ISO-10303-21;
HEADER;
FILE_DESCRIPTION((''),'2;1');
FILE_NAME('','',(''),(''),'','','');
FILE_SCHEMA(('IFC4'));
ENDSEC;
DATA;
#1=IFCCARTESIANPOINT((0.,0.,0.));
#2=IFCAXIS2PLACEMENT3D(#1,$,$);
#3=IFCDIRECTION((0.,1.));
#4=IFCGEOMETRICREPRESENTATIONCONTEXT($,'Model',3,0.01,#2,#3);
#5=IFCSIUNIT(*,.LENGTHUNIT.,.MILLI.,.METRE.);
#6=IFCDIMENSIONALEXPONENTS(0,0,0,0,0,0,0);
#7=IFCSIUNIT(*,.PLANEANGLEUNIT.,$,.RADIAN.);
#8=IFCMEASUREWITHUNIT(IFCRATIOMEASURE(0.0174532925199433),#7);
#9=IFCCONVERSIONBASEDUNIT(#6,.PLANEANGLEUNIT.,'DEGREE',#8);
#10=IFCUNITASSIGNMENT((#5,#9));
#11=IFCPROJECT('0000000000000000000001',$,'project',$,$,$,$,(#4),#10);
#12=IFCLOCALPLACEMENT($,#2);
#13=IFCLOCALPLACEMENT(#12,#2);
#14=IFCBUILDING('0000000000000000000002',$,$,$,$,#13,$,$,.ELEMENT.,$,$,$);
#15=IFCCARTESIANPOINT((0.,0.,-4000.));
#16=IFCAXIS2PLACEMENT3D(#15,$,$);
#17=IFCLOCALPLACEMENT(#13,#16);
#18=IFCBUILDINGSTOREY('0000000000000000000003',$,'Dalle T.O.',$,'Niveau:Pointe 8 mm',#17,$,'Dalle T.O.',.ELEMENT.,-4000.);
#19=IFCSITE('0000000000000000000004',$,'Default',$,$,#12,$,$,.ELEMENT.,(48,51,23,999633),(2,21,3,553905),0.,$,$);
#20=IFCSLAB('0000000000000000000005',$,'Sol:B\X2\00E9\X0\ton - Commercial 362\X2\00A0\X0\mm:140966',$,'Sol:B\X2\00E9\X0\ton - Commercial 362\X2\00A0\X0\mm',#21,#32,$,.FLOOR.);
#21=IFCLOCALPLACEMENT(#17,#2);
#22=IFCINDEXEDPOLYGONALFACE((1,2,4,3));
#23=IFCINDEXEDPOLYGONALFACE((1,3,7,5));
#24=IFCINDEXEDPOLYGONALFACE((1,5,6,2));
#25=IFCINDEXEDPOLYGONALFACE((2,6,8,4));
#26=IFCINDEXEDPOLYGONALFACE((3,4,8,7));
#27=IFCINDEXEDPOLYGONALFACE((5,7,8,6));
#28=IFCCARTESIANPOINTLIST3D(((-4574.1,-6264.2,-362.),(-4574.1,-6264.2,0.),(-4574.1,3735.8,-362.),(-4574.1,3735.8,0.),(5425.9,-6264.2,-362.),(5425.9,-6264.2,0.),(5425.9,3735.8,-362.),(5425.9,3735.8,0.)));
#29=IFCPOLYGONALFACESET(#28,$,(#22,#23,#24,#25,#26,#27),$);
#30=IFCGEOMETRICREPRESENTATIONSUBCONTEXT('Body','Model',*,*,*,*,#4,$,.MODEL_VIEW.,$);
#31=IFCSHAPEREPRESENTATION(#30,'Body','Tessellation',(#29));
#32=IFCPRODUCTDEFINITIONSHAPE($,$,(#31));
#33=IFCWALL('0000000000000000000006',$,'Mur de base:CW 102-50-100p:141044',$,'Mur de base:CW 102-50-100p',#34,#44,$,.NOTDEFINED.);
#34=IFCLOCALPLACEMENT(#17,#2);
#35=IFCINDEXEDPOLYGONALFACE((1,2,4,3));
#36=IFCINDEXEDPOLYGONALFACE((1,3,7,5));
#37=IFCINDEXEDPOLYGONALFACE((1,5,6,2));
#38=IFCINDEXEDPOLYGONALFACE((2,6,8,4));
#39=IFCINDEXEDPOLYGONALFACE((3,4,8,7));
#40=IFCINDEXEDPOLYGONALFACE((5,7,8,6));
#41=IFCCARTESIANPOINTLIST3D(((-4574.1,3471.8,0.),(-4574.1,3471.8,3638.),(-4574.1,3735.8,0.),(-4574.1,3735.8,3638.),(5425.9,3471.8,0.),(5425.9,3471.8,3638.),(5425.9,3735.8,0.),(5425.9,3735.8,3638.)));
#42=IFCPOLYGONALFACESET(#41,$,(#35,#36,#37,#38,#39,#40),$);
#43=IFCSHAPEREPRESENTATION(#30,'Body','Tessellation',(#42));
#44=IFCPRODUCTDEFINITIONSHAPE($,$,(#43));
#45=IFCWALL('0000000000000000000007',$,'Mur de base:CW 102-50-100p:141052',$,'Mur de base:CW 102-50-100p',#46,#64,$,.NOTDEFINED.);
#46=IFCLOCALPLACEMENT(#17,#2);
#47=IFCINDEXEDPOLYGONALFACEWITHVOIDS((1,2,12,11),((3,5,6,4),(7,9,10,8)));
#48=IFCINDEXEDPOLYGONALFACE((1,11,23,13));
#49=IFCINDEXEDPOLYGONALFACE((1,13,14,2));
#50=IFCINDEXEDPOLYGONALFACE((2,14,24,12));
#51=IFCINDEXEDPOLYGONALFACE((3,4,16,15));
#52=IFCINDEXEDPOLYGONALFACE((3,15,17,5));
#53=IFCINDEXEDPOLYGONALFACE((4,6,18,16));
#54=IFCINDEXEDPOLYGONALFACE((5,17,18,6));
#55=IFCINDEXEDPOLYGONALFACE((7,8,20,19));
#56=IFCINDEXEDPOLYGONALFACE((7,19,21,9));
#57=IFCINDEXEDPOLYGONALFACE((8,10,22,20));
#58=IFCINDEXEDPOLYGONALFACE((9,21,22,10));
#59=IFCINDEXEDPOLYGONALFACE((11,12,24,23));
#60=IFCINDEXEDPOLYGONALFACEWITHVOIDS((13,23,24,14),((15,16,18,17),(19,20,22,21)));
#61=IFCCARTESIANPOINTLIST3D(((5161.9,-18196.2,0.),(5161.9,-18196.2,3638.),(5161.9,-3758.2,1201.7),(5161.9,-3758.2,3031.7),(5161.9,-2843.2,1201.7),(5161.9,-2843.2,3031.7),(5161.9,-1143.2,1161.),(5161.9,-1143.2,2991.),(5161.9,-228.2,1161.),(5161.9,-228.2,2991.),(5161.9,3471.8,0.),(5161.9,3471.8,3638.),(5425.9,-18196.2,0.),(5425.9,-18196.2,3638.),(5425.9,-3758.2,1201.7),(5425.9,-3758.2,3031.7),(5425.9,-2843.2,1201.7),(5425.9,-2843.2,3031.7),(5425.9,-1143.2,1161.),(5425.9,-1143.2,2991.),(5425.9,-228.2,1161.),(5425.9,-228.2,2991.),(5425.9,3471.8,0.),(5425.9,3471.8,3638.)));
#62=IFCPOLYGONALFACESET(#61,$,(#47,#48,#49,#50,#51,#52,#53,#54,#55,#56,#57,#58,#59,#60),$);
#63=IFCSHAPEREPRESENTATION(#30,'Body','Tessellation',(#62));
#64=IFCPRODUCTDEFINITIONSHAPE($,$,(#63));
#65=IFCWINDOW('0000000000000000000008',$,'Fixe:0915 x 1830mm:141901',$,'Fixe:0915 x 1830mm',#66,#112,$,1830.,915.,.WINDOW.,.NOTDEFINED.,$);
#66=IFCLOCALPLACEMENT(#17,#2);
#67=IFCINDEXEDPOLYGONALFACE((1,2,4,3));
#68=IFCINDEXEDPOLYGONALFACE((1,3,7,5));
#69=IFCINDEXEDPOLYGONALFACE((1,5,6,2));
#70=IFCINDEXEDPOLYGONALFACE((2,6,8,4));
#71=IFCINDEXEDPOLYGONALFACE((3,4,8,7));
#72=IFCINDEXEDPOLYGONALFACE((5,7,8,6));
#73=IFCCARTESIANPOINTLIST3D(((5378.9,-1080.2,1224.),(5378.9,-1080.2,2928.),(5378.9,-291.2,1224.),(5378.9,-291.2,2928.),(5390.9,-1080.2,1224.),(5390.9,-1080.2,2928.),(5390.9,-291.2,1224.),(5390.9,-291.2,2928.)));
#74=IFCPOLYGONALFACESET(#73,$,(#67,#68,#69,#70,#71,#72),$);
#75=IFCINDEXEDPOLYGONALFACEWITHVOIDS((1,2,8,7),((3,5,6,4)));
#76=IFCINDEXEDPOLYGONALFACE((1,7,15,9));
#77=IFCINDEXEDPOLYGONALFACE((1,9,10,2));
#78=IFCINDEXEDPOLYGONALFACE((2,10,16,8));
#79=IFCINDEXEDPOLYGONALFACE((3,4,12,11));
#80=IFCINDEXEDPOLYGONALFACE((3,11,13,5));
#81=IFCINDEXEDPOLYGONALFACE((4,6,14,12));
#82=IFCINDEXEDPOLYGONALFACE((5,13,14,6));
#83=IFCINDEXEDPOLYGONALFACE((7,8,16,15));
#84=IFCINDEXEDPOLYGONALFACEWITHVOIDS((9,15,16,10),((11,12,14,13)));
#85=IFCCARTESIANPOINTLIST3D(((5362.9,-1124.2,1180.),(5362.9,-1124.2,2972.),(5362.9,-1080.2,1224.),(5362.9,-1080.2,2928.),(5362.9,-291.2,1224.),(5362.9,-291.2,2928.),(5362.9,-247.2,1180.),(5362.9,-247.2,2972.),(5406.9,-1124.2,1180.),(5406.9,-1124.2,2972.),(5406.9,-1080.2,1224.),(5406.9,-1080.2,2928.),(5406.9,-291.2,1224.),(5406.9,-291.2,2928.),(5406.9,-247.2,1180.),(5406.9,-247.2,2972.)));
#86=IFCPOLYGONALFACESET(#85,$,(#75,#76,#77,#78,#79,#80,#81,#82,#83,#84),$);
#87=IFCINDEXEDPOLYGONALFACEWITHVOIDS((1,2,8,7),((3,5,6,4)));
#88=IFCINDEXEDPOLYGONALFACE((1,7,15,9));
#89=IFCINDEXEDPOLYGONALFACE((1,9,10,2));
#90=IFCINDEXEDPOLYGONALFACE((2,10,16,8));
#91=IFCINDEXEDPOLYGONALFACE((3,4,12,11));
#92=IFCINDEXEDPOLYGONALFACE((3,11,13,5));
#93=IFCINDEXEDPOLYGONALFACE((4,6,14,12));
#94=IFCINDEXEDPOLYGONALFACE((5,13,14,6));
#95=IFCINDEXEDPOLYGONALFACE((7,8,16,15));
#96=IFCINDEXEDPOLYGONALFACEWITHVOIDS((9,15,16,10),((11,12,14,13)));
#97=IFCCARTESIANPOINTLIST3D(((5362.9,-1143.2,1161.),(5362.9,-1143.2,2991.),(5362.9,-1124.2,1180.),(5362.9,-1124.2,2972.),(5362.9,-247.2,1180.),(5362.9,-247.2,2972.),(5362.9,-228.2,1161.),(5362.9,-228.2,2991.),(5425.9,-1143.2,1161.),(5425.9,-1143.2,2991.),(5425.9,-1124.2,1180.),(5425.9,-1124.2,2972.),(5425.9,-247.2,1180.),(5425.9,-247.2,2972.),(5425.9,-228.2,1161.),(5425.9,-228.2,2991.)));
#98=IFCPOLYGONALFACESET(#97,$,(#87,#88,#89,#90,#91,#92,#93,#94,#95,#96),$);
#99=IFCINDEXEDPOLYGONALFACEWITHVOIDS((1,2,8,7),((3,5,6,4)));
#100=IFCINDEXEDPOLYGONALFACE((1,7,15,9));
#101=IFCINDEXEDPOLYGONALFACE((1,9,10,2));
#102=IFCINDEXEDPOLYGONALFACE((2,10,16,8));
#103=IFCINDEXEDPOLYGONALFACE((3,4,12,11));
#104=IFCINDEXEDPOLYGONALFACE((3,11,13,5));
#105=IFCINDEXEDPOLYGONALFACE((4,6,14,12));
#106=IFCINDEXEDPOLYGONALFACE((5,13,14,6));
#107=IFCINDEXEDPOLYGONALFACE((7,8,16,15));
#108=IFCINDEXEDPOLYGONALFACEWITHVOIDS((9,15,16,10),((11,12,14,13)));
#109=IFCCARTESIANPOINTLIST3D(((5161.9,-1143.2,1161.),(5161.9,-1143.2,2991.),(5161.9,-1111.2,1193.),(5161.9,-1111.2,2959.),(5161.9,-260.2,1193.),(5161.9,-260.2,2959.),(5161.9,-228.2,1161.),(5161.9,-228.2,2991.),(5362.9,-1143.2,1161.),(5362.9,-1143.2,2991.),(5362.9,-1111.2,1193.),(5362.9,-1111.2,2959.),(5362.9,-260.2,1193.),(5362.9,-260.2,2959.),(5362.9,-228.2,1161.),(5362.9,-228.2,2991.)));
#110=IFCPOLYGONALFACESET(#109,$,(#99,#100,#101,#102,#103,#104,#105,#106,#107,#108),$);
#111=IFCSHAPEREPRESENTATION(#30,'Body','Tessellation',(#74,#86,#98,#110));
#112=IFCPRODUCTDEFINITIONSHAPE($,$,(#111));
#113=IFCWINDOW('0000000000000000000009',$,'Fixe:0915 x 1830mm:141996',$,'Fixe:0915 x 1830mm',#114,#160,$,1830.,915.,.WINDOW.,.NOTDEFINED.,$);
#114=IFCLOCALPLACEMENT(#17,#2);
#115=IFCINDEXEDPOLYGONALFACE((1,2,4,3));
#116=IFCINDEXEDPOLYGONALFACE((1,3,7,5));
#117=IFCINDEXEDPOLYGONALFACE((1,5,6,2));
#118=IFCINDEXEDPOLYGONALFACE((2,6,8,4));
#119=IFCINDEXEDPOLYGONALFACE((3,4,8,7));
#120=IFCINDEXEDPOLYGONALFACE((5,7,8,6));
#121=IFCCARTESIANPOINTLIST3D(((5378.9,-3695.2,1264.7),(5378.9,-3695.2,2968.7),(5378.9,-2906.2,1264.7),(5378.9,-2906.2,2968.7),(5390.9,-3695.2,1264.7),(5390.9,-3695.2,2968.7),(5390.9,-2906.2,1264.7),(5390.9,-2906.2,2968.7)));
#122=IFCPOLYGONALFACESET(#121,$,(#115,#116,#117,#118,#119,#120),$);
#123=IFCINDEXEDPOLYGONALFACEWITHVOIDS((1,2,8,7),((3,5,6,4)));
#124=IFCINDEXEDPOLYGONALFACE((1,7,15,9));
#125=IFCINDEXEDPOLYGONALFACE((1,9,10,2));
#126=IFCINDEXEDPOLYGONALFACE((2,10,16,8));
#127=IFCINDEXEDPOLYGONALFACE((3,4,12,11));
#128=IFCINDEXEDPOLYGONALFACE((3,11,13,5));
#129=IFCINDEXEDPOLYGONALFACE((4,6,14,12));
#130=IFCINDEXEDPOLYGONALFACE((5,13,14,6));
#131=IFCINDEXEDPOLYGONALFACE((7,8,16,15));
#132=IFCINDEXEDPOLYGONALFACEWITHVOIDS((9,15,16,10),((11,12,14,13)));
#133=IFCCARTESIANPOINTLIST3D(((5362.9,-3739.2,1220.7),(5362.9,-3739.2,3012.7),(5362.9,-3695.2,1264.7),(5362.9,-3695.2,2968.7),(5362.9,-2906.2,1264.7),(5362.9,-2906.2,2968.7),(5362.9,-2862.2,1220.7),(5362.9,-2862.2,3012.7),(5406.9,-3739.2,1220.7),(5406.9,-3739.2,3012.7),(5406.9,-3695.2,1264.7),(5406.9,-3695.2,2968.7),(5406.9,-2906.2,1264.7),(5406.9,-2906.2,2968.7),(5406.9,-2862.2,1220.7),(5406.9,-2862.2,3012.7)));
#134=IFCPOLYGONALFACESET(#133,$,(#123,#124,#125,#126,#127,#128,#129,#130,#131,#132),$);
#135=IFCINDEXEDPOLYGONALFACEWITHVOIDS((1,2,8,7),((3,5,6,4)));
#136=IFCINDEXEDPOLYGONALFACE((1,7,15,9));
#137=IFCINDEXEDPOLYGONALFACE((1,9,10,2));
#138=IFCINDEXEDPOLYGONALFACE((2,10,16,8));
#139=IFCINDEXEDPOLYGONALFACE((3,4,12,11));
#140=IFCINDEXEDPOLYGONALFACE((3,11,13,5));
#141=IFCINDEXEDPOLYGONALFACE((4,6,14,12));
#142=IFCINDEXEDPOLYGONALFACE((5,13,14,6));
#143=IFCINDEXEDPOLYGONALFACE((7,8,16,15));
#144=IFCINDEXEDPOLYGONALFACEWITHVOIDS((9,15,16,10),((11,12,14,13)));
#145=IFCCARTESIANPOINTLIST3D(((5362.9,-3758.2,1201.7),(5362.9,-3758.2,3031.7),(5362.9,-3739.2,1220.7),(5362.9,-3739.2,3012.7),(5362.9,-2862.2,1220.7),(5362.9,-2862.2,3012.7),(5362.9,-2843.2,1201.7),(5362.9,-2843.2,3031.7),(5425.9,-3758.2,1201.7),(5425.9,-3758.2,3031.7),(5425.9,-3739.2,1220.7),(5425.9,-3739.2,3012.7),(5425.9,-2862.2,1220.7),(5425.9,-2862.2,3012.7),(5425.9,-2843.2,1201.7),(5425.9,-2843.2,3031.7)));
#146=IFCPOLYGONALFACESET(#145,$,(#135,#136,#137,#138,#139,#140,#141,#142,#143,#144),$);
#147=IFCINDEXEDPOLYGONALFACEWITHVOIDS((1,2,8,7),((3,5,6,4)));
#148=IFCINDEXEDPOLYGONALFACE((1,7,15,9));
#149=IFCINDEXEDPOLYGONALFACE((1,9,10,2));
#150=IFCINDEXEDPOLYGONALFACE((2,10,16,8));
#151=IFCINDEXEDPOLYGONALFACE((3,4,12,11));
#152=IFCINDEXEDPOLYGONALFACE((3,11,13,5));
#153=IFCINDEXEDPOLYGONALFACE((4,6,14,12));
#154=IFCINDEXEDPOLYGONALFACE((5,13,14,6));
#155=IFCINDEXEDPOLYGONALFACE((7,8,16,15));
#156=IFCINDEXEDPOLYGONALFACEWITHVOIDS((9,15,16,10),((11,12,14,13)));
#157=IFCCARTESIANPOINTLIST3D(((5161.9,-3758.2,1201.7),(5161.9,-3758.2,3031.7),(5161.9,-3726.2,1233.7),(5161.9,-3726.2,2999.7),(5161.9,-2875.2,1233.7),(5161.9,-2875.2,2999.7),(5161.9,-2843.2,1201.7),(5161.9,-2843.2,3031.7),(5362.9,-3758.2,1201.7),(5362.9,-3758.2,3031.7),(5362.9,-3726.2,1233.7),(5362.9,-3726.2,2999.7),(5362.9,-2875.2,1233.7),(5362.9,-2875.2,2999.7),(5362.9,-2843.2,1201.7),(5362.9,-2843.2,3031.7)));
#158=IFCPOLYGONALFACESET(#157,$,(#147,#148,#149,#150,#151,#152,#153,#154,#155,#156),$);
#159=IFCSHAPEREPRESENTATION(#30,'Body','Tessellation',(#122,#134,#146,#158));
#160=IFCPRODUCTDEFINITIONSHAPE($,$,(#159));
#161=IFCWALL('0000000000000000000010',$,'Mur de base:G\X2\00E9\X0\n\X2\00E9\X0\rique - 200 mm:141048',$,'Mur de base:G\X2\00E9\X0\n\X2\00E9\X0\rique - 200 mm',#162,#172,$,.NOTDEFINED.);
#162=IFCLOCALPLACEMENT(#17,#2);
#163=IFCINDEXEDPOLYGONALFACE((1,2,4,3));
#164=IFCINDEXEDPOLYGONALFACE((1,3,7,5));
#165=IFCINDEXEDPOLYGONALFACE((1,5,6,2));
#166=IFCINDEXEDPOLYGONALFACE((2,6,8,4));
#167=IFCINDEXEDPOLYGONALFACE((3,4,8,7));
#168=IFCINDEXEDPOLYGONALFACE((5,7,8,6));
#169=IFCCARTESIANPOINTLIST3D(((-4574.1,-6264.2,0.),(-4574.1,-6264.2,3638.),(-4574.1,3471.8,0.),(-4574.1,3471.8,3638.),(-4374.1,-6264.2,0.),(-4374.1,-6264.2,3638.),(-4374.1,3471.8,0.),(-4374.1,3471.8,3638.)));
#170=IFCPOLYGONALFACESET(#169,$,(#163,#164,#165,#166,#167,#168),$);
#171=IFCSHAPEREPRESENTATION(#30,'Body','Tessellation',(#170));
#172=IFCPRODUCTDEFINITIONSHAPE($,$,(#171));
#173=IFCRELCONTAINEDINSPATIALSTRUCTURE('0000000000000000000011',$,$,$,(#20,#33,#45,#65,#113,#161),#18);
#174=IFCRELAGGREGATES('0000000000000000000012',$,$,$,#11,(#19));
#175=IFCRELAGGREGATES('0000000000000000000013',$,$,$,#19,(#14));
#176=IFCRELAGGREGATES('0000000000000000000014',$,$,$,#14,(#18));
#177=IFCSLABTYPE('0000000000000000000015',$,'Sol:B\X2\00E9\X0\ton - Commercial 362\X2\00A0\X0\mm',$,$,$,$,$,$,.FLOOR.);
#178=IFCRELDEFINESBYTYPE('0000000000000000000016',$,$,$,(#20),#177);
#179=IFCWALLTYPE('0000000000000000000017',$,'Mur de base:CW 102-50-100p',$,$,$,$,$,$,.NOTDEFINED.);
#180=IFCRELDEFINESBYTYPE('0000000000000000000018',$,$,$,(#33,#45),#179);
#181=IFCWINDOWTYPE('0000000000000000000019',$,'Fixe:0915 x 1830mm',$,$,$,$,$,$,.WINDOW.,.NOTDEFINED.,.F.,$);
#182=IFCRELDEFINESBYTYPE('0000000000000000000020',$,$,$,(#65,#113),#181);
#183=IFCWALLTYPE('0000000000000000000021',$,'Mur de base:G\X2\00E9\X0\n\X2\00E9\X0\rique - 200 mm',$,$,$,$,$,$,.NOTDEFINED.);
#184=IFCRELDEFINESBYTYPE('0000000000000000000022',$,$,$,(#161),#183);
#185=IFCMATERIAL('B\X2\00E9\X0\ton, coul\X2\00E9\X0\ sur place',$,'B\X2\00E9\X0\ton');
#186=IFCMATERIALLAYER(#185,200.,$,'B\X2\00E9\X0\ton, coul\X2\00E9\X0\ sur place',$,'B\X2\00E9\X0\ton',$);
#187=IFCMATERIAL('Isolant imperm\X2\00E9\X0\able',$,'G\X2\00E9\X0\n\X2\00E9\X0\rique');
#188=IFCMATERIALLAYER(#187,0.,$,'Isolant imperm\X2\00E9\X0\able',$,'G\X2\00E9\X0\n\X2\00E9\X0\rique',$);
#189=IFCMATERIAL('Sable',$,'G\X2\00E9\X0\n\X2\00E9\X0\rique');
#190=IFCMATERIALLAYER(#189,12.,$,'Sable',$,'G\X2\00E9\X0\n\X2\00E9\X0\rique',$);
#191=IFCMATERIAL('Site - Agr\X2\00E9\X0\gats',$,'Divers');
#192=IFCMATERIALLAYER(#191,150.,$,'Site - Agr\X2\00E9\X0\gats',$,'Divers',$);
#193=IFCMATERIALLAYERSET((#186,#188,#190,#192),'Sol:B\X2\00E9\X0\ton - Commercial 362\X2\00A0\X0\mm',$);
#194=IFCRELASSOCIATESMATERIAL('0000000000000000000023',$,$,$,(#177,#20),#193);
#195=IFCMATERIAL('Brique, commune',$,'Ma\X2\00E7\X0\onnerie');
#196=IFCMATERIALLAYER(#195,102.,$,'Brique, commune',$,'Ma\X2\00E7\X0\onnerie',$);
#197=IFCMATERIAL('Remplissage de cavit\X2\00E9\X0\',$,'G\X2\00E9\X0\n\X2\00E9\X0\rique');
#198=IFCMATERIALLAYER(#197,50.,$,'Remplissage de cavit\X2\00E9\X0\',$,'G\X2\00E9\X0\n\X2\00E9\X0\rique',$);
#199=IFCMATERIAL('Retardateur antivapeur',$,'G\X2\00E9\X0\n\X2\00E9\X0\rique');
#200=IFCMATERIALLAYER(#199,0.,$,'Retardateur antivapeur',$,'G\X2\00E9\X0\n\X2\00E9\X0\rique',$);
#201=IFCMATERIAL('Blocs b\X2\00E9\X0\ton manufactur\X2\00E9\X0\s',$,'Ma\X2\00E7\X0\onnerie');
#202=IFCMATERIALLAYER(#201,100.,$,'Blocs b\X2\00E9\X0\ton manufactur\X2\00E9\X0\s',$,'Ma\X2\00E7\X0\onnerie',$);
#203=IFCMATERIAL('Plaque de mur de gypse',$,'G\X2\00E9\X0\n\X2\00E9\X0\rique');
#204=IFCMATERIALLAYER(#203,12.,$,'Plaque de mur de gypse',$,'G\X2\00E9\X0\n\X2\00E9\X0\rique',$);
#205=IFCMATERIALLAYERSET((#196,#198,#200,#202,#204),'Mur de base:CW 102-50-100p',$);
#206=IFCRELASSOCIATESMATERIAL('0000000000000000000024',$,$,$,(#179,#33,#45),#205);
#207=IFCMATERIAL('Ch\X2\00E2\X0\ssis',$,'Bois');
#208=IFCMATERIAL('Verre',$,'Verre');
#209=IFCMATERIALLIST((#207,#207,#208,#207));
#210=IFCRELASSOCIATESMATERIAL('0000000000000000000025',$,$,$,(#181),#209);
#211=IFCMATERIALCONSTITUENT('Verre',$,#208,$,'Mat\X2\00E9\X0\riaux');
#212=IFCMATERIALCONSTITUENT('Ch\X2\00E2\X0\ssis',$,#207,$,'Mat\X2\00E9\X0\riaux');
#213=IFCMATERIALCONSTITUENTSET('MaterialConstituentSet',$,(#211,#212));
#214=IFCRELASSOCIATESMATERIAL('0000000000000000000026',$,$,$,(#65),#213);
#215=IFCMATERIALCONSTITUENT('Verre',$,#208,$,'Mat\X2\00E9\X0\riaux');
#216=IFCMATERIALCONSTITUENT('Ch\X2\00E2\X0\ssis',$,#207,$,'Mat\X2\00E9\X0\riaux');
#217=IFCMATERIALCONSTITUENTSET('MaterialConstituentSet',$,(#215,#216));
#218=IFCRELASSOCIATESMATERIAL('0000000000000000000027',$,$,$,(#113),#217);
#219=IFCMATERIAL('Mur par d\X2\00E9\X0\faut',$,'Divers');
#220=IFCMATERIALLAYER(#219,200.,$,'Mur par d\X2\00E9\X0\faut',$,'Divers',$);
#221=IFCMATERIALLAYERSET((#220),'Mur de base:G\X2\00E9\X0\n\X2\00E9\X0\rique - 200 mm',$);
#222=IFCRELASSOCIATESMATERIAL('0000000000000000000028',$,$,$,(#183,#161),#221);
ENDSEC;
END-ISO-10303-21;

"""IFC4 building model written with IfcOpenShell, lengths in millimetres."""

from ifc_helpers import new_model, entity, si_unit, converted_unit, direction, frame, frame_2d, origin, place, context, subcontext, project, spatial, polyline, rectangle, outline, extrude, source, transform, mapped, material, material_list, layer, layer_set, layer_usage, constituent, constituent_set, type_object, type_shapes, element, fill, save


model = new_model("IFC4")

# Units and contexts
model_context = context("Model", 3, precision=0.01, world=origin(), true_north=direction((0.0, 1.0)))
body_context = subcontext(model_context, "Body", "Model", "MODEL_VIEW")
ifc_project = project(units=[si_unit("LENGTHUNIT", "METRE", prefix="MILLI"), converted_unit("PLANEANGLEUNIT", "DEGREE", entity("IfcRatioMeasure", 0.0174532925199433), si_unit("PLANEANGLEUNIT", "RADIAN"), dimensions=[0, 0, 0, 0, 0, 0, 0])], contexts=[model_context])

# Site, building, storey
site_placement = place(None, origin())
site = spatial("IfcSite", under=ifc_project, at=site_placement, Name="Default", CompositionType="ELEMENT", RefLatitude=(48, 51, 23, 999633), RefLongitude=(2, 21, 3, 553905), RefElevation=0.0)
building_placement = place(site_placement, origin())
building = spatial("IfcBuilding", under=site, at=building_placement, CompositionType="ELEMENT")
storey_placement = place(building_placement, frame((0.0, 0.0, -4000.0)))
storey = spatial("IfcBuildingStorey", under=building, at=storey_placement, Name="Dalle T.O.", ObjectType="Niveau:Pointe 8 mm", LongName="Dalle T.O.", CompositionType="ELEMENT", Elevation=-4000.0)

# Slab
ifc_material_1 = material(Name="Béton, coulé sur place", Category="Béton")
ifc_layer_1 = layer(ifc_material_1, 200.0, Name="Béton, coulé sur place", Category="Béton")
ifc_material_2 = material(Name="Isolant imperméable", Category="Générique")
ifc_layer_2 = layer(ifc_material_2, 0.0, Name="Isolant imperméable", Category="Générique")
ifc_material_3 = material(Name="Sable", Category="Générique")
ifc_layer_3 = layer(ifc_material_3, 12.0, Name="Sable", Category="Générique")
ifc_material_4 = material(Name="Site - Agrégats", Category="Divers")
ifc_layer_4 = layer(ifc_material_4, 150.0, Name="Site - Agrégats", Category="Divers")
ifc_layer_set_1 = layer_set([ifc_layer_1, ifc_layer_2, ifc_layer_3, ifc_layer_4], Name="Sol:Béton - Commercial 362 mm")
ifc_layer_usage_1 = layer_usage(ifc_layer_set_1, "AXIS3", "POSITIVE", 0.0)
slab_type = type_object("IfcSlabType", Name="Sol:Béton - Commercial 362 mm", PredefinedType="FLOOR", material=ifc_layer_set_1)
slab_placement = place(storey_placement, origin())
element("IfcSlab", 1, at=slab_placement, inside=storey, type_object=slab_type, material=ifc_layer_usage_1, Name="Sol:Béton - Commercial 362 mm:140966", ObjectType="Sol:Béton - Commercial 362 mm", PredefinedType="FLOOR", context=body_context, shape_type="SweptSolid", body=[
    extrude(rectangle(XDim=10000.0, YDim=10000.0, at=frame_2d((0.0, 0.0), x_axis=(1.0, 0.0))), frame((425.9, -1264.2, 0.0), z_axis=(0.0, 0.0, -1.0), x_axis=(0.0, 1.0, 0.0)), (0.0, 0.0, 1.0), 362.0),
])

# Wall
ifc_material_5 = material(Name="Brique, commune", Category="Maçonnerie")
ifc_layer_5 = layer(ifc_material_5, 102.0, Name="Brique, commune", Category="Maçonnerie")
ifc_material_6 = material(Name="Remplissage de cavité", Category="Générique")
ifc_layer_6 = layer(ifc_material_6, 50.0, Name="Remplissage de cavité", Category="Générique")
ifc_material_7 = material(Name="Retardateur antivapeur", Category="Générique")
ifc_layer_7 = layer(ifc_material_7, 0.0, Name="Retardateur antivapeur", Category="Générique")
ifc_material_8 = material(Name="Blocs béton manufacturés", Category="Maçonnerie")
ifc_layer_8 = layer(ifc_material_8, 100.0, Name="Blocs béton manufacturés", Category="Maçonnerie")
ifc_material_9 = material(Name="Plaque de mur de gypse", Category="Générique")
ifc_layer_9 = layer(ifc_material_9, 12.0, Name="Plaque de mur de gypse", Category="Générique")
ifc_layer_set_2 = layer_set([ifc_layer_5, ifc_layer_6, ifc_layer_7, ifc_layer_8, ifc_layer_9], Name="Mur de base:CW 102-50-100p")
ifc_layer_usage_2 = layer_usage(ifc_layer_set_2, "AXIS2", "NEGATIVE", 132.0)
wall_type_1 = type_object("IfcWallType", Name="Mur de base:CW 102-50-100p", PredefinedType="NOTDEFINED", material=ifc_layer_set_2)
wall_1_placement = place(storey_placement, frame((-4574.1, 3603.8, 0.0)))
element("IfcWall", 2, at=wall_1_placement, inside=storey, type_object=wall_type_1, material=ifc_layer_usage_2, Name="Mur de base:CW 102-50-100p:141044", ObjectType="Mur de base:CW 102-50-100p", PredefinedType="NOTDEFINED", context=body_context, shape_type="SweptSolid", body=[
    extrude(rectangle(XDim=10000.0, YDim=264.0, at=frame_2d((5000.0, 0.0), x_axis=(-1.0, 0.0))), origin(), (0.0, 0.0, 1.0), 3638.0),
])

# Wall, openings, windows
ifc_layer_usage_3 = layer_usage(ifc_layer_set_2, "AXIS2", "NEGATIVE", 132.0)
wall_2_placement = place(storey_placement, frame((5293.9, 3471.8, 0.0), z_axis=(0.0, 0.0, 1.0), x_axis=(0.0, -1.0, 0.0)))
wall_2 = element("IfcWall", 3, at=wall_2_placement, inside=storey, type_object=wall_type_1, material=ifc_layer_usage_3, Name="Mur de base:CW 102-50-100p:141052", ObjectType="Mur de base:CW 102-50-100p", PredefinedType="NOTDEFINED", context=body_context, shape_type="SweptSolid", body=[
    extrude(rectangle(XDim=21668.0, YDim=264.0, at=frame_2d((10834.0, 0.0), x_axis=(-1.0, 0.0))), origin(), (0.0, 0.0, 1.0), 3638.0),
])
opening_1_placement = place(wall_2_placement, frame((3700.0, -132.0, 1161.0)))
opening_1 = element("IfcOpeningElement", 4, at=opening_1_placement, cuts=wall_2, ObjectType="Opening", PredefinedType="OPENING", context=body_context, shape_type="SweptSolid", body=[
    extrude(rectangle(XDim=1830.0, YDim=915.0, at=frame_2d((915.0, 457.5), x_axis=(1.0, 0.0))), frame((0.0, 0.0, 0.0), z_axis=(0.0, 1.0, 0.0), x_axis=(0.0, 0.0, 1.0)), (0.0, 0.0, 1.0), 264.0),
])
opening_2_placement = place(wall_2_placement, frame((6315.0, -132.0, 1201.7)))
opening_2 = element("IfcOpeningElement", 5, at=opening_2_placement, cuts=wall_2, ObjectType="Opening", PredefinedType="OPENING", context=body_context, shape_type="SweptSolid", body=[
    extrude(rectangle(XDim=1830.0, YDim=915.0, at=frame_2d((915.0, 457.5), x_axis=(1.0, 0.0))), frame((0.0, 0.0, 0.0), z_axis=(0.0, 1.0, 0.0), x_axis=(0.0, 0.0, 1.0)), (0.0, 0.0, 1.0), 264.0),
])
ifc_material_10 = material(Name="Verre", Category="Verre")
ifc_constituent_1 = constituent(ifc_material_10, Name="Verre", Category="Matériaux")
ifc_material_11 = material(Name="Châssis", Category="Bois")
ifc_constituent_2 = constituent(ifc_material_11, Name="Châssis", Category="Matériaux")
ifc_constituent_set_1 = constituent_set(constituents=[ifc_constituent_1, ifc_constituent_2], Name="MaterialConstituentSet")
ifc_material_list = material_list([ifc_material_11, ifc_material_11, ifc_material_10, ifc_material_11])
window_type = type_object("IfcWindowType", Name="Fixe:0915 x 1830mm", ParameterTakesPrecedence=False, PartitioningType="NOTDEFINED", PredefinedType="WINDOW", material=ifc_material_list)
shared_shape = source(origin(), body_context, "Body", "SweptSolid", [
    extrude(rectangle(XDim=12.0, YDim=789.0, at=frame_2d((0.0, 0.0), x_axis=(1.0, 0.0))), frame((457.5, 223.0, 63.0), z_axis=(0.0, 0.0, 1.0), x_axis=(0.0, -1.0, 0.0)), (0.0, 0.0, 1.0), 1704.0),
    extrude(outline(polyline([(-438.5, -896.0), (438.5, -896.0), (438.5, 896.0), (-438.5, 896.0), (-438.5, -896.0)]), holes=[polyline([(-394.5, -852.0), (-394.5, 852.0), (394.5, 852.0), (394.5, -852.0), (-394.5, -852.0)])]), frame((457.5, 201.0, 915.0), z_axis=(0.0, 1.0, 0.0), x_axis=(1.0, 0.0, 0.0)), (0.0, 0.0, 1.0), 44.0),
    extrude(outline(polyline([(-457.5, -915.0), (457.5, -915.0), (457.5, 915.0), (-457.5, 915.0), (-457.5, -915.0)]), holes=[polyline([(-438.5, -896.0), (-438.5, 896.0), (438.5, 896.0), (438.5, -896.0), (-438.5, -896.0)])]), frame((457.5, 201.0, 915.0), z_axis=(0.0, 1.0, 0.0), x_axis=(1.0, 0.0, 0.0)), (0.0, 0.0, 1.0), 63.0),
    extrude(outline(polyline([(-457.5, -915.0), (457.5, -915.0), (457.5, 915.0), (-457.5, 915.0), (-457.5, -915.0)]), holes=[polyline([(-425.5, -883.0), (-425.5, 883.0), (425.5, 883.0), (425.5, -883.0), (-425.5, -883.0)])]), frame((457.5, 0.0, 915.0), z_axis=(0.0, 1.0, 0.0), x_axis=(1.0, 0.0, 0.0)), (0.0, 0.0, 1.0), 201.0),
])
type_shapes(window_type, [shared_shape])
window_1_placement = place(opening_1_placement, origin())
window_1 = element("IfcWindow", 6, at=window_1_placement, inside=storey, type_object=window_type, material=ifc_constituent_set_1, Name="Fixe:0915 x 1830mm:141901", ObjectType="Fixe:0915 x 1830mm", OverallHeight=1830.0, OverallWidth=915.0, PartitioningType="NOTDEFINED", PredefinedType="WINDOW", context=body_context, shape_type="MappedRepresentation", body=[
    mapped(shared_shape, transform((0.0, 0.0, 0.0), scale=1.0)),
])
fill(opening_1, window_1)
ifc_constituent_3 = constituent(ifc_material_10, Name="Verre", Category="Matériaux")
ifc_constituent_4 = constituent(ifc_material_11, Name="Châssis", Category="Matériaux")
ifc_constituent_set_2 = constituent_set(constituents=[ifc_constituent_3, ifc_constituent_4], Name="MaterialConstituentSet")
window_2_placement = place(opening_2_placement, origin())
window_2 = element("IfcWindow", 7, at=window_2_placement, inside=storey, type_object=window_type, material=ifc_constituent_set_2, Name="Fixe:0915 x 1830mm:141996", ObjectType="Fixe:0915 x 1830mm", OverallHeight=1830.0, OverallWidth=915.0, PartitioningType="NOTDEFINED", PredefinedType="WINDOW", context=body_context, shape_type="MappedRepresentation", body=[
    mapped(shared_shape, transform((0.0, 0.0, 0.0), scale=1.0)),
])
fill(opening_2, window_2)

# Wall
ifc_material_12 = material(Name="Mur par défaut", Category="Divers")
ifc_layer_10 = layer(ifc_material_12, 200.0, Name="Mur par défaut", Category="Divers")
ifc_layer_set_3 = layer_set([ifc_layer_10], Name="Mur de base:Générique - 200 mm")
ifc_layer_usage_4 = layer_usage(ifc_layer_set_3, "AXIS2", "NEGATIVE", 100.0)
wall_type_2 = type_object("IfcWallType", Name="Mur de base:Générique - 200 mm", PredefinedType="NOTDEFINED", material=ifc_layer_set_3)
wall_3_placement = place(storey_placement, frame((-4474.1, -6264.2, 0.0), z_axis=(0.0, 0.0, 1.0), x_axis=(0.0, 1.0, 0.0)))
element("IfcWall", 8, at=wall_3_placement, inside=storey, type_object=wall_type_2, material=ifc_layer_usage_4, Name="Mur de base:Générique - 200 mm:141048", ObjectType="Mur de base:Générique - 200 mm", PredefinedType="NOTDEFINED", context=body_context, shape_type="SweptSolid", body=[
    extrude(rectangle(XDim=9736.0, YDim=200.0, at=frame_2d((4868.0, 0.0), x_axis=(-1.0, 0.0))), origin(), (0.0, 0.0, 1.0), 3638.0),
])

save(model, "model.ifc")
